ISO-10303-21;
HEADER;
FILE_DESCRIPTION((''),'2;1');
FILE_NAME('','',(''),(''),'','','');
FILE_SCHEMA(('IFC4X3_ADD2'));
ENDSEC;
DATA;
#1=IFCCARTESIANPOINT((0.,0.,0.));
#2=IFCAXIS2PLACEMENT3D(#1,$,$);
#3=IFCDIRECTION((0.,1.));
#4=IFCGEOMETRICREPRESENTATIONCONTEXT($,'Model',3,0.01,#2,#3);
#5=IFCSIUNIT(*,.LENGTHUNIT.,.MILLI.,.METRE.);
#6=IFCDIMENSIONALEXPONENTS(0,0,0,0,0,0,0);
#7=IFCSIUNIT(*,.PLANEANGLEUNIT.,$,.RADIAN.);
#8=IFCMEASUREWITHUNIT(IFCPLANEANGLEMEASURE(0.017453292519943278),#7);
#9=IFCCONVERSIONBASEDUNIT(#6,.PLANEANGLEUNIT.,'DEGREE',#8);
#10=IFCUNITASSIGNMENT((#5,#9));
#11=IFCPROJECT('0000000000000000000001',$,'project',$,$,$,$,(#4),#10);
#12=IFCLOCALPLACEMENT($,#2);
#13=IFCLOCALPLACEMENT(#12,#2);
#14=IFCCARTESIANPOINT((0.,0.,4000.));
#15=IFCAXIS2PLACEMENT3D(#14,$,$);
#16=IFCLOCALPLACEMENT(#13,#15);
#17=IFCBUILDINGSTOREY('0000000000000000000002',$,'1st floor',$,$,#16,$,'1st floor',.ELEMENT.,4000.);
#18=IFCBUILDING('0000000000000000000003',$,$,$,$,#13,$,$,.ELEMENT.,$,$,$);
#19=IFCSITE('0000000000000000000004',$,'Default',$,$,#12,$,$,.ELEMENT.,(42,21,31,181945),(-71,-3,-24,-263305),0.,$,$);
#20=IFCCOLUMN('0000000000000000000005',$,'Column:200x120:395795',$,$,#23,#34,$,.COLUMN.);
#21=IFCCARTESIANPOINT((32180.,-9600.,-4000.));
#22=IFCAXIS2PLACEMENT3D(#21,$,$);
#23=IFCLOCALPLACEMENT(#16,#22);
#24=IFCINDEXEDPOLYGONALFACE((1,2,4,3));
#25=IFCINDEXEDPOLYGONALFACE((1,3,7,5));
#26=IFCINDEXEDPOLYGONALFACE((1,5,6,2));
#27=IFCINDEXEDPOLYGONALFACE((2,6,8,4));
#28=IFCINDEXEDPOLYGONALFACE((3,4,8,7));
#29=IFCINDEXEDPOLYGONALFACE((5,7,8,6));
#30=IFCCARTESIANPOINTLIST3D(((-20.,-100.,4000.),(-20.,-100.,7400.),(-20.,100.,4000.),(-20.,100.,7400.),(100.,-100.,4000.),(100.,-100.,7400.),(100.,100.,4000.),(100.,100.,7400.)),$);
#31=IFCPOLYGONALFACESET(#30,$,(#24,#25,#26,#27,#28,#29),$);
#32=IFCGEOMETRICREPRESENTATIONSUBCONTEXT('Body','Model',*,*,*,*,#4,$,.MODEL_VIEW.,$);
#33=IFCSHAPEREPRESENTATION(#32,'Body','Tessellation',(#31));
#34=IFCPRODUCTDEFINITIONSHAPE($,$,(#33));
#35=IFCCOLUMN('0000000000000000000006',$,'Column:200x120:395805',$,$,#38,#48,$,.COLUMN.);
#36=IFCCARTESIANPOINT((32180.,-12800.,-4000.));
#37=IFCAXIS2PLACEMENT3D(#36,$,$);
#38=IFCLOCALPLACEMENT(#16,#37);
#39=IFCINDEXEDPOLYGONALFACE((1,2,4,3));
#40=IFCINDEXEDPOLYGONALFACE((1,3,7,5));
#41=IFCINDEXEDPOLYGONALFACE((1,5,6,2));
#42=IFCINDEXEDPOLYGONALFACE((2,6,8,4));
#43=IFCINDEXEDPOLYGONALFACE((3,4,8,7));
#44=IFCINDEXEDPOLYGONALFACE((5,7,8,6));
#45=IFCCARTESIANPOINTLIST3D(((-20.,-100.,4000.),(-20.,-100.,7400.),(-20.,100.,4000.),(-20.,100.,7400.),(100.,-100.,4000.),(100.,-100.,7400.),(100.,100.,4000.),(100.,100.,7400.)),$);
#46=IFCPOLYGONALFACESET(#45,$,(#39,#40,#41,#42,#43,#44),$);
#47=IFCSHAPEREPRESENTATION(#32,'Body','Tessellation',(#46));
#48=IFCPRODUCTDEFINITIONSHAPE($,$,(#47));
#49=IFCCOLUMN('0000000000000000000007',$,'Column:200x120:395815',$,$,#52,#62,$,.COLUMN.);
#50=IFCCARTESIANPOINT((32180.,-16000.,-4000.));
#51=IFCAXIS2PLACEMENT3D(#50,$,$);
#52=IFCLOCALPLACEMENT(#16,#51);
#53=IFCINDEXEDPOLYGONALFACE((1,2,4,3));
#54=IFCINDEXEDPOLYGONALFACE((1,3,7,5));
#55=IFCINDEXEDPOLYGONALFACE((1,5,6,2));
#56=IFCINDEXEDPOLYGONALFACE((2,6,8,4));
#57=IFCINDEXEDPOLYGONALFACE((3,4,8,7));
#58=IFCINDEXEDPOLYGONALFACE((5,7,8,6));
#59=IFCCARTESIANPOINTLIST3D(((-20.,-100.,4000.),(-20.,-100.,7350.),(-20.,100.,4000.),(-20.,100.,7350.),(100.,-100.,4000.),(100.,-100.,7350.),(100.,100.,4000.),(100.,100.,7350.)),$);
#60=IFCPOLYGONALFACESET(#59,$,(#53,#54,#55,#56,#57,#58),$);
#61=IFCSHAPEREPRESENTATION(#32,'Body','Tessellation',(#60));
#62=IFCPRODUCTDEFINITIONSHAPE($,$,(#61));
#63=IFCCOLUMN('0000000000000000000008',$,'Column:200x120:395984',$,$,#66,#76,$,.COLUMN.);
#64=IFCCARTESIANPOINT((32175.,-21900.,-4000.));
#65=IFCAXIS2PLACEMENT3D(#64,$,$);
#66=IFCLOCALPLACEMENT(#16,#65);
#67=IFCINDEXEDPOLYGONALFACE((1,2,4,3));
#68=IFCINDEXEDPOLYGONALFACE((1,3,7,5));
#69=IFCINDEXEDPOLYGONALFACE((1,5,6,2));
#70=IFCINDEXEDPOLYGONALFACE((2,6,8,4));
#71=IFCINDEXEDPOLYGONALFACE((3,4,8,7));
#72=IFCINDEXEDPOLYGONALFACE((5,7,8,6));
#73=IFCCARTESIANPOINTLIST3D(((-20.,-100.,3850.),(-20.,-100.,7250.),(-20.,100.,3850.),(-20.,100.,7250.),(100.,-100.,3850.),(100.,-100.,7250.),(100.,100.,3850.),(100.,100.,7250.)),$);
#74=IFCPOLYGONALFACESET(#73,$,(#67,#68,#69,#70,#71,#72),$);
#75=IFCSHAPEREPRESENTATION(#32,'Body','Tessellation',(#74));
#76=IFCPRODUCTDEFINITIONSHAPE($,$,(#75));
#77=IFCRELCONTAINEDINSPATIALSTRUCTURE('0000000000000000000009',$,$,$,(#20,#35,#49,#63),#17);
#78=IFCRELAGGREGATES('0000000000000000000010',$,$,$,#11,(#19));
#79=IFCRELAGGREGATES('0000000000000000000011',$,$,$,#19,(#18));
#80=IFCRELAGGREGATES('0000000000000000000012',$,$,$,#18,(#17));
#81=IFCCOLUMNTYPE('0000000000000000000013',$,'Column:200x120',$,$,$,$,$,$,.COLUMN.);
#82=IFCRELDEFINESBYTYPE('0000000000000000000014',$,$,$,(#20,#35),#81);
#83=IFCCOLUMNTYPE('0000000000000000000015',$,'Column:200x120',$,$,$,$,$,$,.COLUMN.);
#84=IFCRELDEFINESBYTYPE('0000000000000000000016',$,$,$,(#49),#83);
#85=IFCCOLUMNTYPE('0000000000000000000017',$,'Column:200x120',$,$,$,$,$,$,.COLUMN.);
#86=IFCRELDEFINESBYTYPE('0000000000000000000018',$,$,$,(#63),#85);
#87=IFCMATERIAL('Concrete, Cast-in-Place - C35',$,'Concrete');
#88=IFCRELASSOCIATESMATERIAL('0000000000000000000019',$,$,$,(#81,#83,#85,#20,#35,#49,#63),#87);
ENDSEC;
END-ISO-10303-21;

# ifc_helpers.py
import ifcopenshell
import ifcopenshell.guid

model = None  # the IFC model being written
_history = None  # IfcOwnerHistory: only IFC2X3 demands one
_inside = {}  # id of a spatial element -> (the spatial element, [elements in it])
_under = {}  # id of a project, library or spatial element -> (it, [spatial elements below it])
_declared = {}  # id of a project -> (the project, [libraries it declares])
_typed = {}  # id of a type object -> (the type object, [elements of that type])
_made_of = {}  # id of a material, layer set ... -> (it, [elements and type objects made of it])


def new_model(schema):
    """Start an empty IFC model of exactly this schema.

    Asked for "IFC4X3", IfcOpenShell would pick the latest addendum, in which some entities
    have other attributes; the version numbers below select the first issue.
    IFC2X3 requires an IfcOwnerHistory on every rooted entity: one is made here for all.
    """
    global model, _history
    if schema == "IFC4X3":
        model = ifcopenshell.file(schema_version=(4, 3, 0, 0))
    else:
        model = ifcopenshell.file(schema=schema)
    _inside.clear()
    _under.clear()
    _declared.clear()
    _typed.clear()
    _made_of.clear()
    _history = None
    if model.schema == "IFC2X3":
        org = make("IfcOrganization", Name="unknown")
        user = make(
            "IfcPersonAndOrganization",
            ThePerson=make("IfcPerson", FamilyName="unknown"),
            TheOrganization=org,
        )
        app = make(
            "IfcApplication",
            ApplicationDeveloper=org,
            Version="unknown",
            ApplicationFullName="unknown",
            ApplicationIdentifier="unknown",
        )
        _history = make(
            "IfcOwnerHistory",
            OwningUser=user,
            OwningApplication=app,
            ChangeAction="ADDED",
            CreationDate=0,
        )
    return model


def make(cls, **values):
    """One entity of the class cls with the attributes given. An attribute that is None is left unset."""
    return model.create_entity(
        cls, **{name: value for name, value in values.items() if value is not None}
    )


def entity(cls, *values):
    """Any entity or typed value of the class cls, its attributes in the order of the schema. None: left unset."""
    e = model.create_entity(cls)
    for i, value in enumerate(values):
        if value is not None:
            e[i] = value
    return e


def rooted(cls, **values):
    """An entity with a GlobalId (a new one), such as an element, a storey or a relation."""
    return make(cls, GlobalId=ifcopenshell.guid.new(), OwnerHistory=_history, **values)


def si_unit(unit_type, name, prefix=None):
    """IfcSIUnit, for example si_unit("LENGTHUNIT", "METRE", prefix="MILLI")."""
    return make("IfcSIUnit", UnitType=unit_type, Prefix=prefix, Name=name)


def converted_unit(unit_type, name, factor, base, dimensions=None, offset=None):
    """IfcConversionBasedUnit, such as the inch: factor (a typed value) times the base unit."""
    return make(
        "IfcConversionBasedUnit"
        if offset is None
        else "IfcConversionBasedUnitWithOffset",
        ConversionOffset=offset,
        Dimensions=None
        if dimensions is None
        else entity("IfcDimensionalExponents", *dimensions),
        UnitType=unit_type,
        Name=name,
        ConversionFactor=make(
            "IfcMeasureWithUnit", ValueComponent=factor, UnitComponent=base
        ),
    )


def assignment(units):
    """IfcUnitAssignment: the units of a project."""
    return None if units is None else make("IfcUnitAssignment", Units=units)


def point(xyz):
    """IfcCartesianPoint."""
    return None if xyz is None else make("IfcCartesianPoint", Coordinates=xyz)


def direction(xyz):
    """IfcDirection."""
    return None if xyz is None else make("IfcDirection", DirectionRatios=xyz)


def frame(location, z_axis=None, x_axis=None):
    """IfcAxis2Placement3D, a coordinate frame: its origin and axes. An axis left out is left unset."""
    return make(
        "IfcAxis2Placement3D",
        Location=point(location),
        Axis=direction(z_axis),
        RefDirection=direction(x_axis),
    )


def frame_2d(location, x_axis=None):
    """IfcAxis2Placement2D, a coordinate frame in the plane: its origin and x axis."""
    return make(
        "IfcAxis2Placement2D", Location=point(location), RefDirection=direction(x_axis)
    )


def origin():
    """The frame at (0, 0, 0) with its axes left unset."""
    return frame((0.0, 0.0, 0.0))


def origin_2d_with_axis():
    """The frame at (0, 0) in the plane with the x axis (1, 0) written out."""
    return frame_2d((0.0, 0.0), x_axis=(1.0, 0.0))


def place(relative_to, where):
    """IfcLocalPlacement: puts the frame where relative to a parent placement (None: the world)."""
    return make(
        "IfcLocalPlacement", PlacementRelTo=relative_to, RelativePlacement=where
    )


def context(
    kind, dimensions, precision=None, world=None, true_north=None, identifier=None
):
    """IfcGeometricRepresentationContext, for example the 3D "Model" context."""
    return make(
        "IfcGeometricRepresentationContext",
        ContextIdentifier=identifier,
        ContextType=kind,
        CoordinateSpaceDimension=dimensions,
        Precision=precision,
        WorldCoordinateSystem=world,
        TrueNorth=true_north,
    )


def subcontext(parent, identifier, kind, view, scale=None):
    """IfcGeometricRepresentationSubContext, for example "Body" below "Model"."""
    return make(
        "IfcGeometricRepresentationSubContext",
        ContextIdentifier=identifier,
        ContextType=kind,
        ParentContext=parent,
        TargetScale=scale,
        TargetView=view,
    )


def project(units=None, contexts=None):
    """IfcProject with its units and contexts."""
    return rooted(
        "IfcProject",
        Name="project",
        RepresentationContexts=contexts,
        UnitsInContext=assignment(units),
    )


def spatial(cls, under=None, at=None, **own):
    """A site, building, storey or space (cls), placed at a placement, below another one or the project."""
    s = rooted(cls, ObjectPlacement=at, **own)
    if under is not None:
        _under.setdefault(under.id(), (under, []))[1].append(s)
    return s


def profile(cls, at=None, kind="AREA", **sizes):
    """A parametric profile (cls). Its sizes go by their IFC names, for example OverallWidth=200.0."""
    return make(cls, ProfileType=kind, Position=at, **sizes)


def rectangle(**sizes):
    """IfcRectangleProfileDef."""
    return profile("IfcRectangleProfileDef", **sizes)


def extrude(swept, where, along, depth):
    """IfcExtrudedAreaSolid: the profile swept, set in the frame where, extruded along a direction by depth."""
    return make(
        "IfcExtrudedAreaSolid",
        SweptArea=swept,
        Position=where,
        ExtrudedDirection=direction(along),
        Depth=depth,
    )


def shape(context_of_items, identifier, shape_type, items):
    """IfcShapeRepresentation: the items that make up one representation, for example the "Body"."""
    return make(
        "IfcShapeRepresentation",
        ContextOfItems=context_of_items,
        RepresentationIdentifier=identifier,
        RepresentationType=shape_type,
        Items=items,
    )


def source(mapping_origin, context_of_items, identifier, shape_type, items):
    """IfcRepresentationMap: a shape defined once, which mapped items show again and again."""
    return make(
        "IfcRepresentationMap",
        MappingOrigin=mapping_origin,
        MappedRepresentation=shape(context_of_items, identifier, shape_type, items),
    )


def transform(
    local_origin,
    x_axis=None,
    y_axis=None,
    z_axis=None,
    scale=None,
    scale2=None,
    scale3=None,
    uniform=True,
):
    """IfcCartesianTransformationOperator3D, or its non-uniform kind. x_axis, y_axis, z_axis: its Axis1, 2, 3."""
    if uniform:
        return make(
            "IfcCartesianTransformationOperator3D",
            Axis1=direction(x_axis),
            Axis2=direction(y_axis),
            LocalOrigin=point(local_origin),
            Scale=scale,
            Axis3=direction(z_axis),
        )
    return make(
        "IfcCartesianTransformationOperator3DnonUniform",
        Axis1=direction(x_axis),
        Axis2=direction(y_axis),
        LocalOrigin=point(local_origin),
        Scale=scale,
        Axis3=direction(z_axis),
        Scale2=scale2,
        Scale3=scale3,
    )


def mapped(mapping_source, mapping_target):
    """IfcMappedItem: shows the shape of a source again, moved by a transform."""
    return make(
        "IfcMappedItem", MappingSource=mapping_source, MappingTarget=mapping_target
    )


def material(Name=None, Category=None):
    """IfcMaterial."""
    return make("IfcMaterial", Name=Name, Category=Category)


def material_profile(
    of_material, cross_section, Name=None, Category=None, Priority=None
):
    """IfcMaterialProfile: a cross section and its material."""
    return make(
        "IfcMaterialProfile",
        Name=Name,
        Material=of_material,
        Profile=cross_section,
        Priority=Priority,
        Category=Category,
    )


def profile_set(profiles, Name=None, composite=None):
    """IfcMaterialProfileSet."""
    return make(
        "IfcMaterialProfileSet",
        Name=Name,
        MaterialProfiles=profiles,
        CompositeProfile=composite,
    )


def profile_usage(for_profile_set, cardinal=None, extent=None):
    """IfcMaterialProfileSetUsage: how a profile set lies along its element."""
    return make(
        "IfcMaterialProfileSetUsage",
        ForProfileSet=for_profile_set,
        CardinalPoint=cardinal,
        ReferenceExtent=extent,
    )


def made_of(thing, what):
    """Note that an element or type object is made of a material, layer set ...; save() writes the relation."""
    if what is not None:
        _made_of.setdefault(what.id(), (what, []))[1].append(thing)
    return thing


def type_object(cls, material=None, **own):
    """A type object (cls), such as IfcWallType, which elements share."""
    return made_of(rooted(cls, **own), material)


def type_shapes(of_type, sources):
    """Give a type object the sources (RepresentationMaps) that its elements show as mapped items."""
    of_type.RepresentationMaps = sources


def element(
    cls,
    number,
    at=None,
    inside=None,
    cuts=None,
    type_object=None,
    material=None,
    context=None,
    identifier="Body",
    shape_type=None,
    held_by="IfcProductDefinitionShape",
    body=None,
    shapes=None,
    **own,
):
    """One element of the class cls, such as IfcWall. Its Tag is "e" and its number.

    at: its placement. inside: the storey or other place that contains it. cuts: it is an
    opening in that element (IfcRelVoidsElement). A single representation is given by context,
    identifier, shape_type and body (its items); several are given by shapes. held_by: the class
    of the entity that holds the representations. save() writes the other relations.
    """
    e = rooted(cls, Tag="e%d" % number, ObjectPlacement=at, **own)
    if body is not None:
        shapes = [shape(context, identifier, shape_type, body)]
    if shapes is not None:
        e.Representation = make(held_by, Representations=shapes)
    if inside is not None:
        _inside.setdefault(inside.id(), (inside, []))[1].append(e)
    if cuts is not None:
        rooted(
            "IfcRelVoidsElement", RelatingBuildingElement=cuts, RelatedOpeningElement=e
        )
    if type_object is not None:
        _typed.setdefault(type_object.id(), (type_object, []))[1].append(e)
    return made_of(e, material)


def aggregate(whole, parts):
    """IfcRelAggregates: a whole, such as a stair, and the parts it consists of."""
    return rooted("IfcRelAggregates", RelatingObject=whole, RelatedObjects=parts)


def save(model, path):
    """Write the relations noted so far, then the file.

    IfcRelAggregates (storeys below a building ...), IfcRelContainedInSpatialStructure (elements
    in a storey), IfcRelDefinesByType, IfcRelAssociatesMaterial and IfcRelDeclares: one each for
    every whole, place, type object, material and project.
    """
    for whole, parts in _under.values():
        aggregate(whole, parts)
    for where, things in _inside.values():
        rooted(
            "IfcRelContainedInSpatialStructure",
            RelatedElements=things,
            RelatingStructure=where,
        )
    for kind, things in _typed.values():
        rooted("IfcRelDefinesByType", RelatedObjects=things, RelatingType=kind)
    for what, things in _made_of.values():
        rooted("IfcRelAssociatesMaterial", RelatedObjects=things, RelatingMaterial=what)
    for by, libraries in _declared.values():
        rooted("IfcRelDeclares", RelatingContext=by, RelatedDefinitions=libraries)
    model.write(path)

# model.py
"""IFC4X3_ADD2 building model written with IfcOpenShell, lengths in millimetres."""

from ifc_helpers import new_model, entity, si_unit, converted_unit, direction, frame, origin, origin_2d_with_axis, place, context, subcontext, project, spatial, rectangle, extrude, source, transform, mapped, material, material_profile, profile_set, profile_usage, type_object, type_shapes, element, save


model = new_model("IFC4X3_ADD2")

# Units and contexts
model_context = context("Model", 3, precision=0.01, world=origin(), true_north=direction((0.0, 1.0)))
body_context = subcontext(model_context, "Body", "Model", "MODEL_VIEW")
ifc_project = project(units=[si_unit("LENGTHUNIT", "METRE", prefix="MILLI"), converted_unit("PLANEANGLEUNIT", "DEGREE", entity("IfcPlaneAngleMeasure", 0.017453292519943278), si_unit("PLANEANGLEUNIT", "RADIAN"), dimensions=[0, 0, 0, 0, 0, 0, 0])], contexts=[model_context])

# Site, building, storey
site_placement = place(None, origin())
site = spatial("IfcSite", under=ifc_project, at=site_placement, Name="Default", CompositionType="ELEMENT", RefLatitude=(42, 21, 31, 181945), RefLongitude=(-71, -3, -24, -263305), RefElevation=0.0)
building_placement = place(site_placement, origin())
building = spatial("IfcBuilding", under=site, at=building_placement, CompositionType="ELEMENT")
storey_placement = place(building_placement, frame((0.0, 0.0, 4000.0)))
storey = spatial("IfcBuildingStorey", under=building, at=storey_placement, Name="1st floor", LongName="1st floor", CompositionType="ELEMENT", Elevation=4000.0)

# Columns
ifc_material_1 = material(Name="Concrete, Cast-in-Place - C35", Category="Concrete")
ifc_material_profile_1 = material_profile(ifc_material_1, rectangle(XDim=120.0, YDim=200.0, at=origin_2d_with_axis()), Name="200x120")
ifc_profile_set_1 = profile_set([ifc_material_profile_1], Name="200x120")
ifc_profile_usage_1 = profile_usage(ifc_profile_set_1)
column_type_1 = type_object("IfcColumnType", Name="Column:200x120", PredefinedType="COLUMN", material=ifc_profile_set_1)
shared_shape_1 = source(origin(), body_context, "Body", "SweptSolid", [
    extrude(rectangle(XDim=120.0, YDim=200.0, at=origin_2d_with_axis()), frame((40.0, 0.0, 4000.0), z_axis=(0.0, 0.0, 1.0), x_axis=(-1.0, 0.0, 0.0)), (0.0, 0.0, 1.0), 3400.0),
])
type_shapes(column_type_1, [shared_shape_1])
for number, where, name in (
    (1, (32180.0, -9600.0, -4000.0), "Column:200x120:395795"),
    (2, (32180.0, -12800.0, -4000.0), "Column:200x120:395805"),
):
    element("IfcColumn", number, at=place(storey_placement, frame(where)), inside=storey, type_object=column_type_1, material=ifc_profile_usage_1, Name=name, PredefinedType="COLUMN", context=body_context, shape_type="MappedRepresentation", body=[
        mapped(shared_shape_1, transform((0.0, 0.0, 0.0), scale=1.0)),
    ])
column_type_2 = type_object("IfcColumnType", Name="Column:200x120", PredefinedType="COLUMN", material=ifc_profile_set_1)
shared_shape_2 = source(origin(), body_context, "Body", "SweptSolid", [
    extrude(rectangle(XDim=120.0, YDim=200.0, at=origin_2d_with_axis()), frame((40.0, 0.0, 4000.0), z_axis=(0.0, 0.0, 1.0), x_axis=(-1.0, 0.0, 0.0)), (0.0, 0.0, 1.0), 3350.0),
])
type_shapes(column_type_2, [shared_shape_2])
column_1_placement = place(storey_placement, frame((32180.0, -16000.0, -4000.0)))
element("IfcColumn", 3, at=column_1_placement, inside=storey, type_object=column_type_2, material=ifc_profile_usage_1, Name="Column:200x120:395815", PredefinedType="COLUMN", context=body_context, shape_type="MappedRepresentation", body=[
    mapped(shared_shape_2, transform((0.0, 0.0, 0.0), scale=1.0)),
])
column_type_3 = type_object("IfcColumnType", Name="Column:200x120", PredefinedType="COLUMN", material=ifc_profile_set_1)
shared_shape_3 = source(origin(), body_context, "Body", "SweptSolid", [
    extrude(rectangle(XDim=120.0, YDim=200.0, at=origin_2d_with_axis()), frame((40.0, 0.0, 3850.0), z_axis=(0.0, 0.0, 1.0), x_axis=(-1.0, 0.0, 0.0)), (0.0, 0.0, 1.0), 3400.0),
])
type_shapes(column_type_3, [shared_shape_3])
column_2_placement = place(storey_placement, frame((32175.0, -21900.0, -4000.0)))
element("IfcColumn", 4, at=column_2_placement, inside=storey, type_object=column_type_3, material=ifc_profile_usage_1, Name="Column:200x120:395984", PredefinedType="COLUMN", context=body_context, shape_type="MappedRepresentation", body=[
    mapped(shared_shape_3, transform((0.0, 0.0, 0.0), scale=1.0)),
])

save(model, "model.ifc")
